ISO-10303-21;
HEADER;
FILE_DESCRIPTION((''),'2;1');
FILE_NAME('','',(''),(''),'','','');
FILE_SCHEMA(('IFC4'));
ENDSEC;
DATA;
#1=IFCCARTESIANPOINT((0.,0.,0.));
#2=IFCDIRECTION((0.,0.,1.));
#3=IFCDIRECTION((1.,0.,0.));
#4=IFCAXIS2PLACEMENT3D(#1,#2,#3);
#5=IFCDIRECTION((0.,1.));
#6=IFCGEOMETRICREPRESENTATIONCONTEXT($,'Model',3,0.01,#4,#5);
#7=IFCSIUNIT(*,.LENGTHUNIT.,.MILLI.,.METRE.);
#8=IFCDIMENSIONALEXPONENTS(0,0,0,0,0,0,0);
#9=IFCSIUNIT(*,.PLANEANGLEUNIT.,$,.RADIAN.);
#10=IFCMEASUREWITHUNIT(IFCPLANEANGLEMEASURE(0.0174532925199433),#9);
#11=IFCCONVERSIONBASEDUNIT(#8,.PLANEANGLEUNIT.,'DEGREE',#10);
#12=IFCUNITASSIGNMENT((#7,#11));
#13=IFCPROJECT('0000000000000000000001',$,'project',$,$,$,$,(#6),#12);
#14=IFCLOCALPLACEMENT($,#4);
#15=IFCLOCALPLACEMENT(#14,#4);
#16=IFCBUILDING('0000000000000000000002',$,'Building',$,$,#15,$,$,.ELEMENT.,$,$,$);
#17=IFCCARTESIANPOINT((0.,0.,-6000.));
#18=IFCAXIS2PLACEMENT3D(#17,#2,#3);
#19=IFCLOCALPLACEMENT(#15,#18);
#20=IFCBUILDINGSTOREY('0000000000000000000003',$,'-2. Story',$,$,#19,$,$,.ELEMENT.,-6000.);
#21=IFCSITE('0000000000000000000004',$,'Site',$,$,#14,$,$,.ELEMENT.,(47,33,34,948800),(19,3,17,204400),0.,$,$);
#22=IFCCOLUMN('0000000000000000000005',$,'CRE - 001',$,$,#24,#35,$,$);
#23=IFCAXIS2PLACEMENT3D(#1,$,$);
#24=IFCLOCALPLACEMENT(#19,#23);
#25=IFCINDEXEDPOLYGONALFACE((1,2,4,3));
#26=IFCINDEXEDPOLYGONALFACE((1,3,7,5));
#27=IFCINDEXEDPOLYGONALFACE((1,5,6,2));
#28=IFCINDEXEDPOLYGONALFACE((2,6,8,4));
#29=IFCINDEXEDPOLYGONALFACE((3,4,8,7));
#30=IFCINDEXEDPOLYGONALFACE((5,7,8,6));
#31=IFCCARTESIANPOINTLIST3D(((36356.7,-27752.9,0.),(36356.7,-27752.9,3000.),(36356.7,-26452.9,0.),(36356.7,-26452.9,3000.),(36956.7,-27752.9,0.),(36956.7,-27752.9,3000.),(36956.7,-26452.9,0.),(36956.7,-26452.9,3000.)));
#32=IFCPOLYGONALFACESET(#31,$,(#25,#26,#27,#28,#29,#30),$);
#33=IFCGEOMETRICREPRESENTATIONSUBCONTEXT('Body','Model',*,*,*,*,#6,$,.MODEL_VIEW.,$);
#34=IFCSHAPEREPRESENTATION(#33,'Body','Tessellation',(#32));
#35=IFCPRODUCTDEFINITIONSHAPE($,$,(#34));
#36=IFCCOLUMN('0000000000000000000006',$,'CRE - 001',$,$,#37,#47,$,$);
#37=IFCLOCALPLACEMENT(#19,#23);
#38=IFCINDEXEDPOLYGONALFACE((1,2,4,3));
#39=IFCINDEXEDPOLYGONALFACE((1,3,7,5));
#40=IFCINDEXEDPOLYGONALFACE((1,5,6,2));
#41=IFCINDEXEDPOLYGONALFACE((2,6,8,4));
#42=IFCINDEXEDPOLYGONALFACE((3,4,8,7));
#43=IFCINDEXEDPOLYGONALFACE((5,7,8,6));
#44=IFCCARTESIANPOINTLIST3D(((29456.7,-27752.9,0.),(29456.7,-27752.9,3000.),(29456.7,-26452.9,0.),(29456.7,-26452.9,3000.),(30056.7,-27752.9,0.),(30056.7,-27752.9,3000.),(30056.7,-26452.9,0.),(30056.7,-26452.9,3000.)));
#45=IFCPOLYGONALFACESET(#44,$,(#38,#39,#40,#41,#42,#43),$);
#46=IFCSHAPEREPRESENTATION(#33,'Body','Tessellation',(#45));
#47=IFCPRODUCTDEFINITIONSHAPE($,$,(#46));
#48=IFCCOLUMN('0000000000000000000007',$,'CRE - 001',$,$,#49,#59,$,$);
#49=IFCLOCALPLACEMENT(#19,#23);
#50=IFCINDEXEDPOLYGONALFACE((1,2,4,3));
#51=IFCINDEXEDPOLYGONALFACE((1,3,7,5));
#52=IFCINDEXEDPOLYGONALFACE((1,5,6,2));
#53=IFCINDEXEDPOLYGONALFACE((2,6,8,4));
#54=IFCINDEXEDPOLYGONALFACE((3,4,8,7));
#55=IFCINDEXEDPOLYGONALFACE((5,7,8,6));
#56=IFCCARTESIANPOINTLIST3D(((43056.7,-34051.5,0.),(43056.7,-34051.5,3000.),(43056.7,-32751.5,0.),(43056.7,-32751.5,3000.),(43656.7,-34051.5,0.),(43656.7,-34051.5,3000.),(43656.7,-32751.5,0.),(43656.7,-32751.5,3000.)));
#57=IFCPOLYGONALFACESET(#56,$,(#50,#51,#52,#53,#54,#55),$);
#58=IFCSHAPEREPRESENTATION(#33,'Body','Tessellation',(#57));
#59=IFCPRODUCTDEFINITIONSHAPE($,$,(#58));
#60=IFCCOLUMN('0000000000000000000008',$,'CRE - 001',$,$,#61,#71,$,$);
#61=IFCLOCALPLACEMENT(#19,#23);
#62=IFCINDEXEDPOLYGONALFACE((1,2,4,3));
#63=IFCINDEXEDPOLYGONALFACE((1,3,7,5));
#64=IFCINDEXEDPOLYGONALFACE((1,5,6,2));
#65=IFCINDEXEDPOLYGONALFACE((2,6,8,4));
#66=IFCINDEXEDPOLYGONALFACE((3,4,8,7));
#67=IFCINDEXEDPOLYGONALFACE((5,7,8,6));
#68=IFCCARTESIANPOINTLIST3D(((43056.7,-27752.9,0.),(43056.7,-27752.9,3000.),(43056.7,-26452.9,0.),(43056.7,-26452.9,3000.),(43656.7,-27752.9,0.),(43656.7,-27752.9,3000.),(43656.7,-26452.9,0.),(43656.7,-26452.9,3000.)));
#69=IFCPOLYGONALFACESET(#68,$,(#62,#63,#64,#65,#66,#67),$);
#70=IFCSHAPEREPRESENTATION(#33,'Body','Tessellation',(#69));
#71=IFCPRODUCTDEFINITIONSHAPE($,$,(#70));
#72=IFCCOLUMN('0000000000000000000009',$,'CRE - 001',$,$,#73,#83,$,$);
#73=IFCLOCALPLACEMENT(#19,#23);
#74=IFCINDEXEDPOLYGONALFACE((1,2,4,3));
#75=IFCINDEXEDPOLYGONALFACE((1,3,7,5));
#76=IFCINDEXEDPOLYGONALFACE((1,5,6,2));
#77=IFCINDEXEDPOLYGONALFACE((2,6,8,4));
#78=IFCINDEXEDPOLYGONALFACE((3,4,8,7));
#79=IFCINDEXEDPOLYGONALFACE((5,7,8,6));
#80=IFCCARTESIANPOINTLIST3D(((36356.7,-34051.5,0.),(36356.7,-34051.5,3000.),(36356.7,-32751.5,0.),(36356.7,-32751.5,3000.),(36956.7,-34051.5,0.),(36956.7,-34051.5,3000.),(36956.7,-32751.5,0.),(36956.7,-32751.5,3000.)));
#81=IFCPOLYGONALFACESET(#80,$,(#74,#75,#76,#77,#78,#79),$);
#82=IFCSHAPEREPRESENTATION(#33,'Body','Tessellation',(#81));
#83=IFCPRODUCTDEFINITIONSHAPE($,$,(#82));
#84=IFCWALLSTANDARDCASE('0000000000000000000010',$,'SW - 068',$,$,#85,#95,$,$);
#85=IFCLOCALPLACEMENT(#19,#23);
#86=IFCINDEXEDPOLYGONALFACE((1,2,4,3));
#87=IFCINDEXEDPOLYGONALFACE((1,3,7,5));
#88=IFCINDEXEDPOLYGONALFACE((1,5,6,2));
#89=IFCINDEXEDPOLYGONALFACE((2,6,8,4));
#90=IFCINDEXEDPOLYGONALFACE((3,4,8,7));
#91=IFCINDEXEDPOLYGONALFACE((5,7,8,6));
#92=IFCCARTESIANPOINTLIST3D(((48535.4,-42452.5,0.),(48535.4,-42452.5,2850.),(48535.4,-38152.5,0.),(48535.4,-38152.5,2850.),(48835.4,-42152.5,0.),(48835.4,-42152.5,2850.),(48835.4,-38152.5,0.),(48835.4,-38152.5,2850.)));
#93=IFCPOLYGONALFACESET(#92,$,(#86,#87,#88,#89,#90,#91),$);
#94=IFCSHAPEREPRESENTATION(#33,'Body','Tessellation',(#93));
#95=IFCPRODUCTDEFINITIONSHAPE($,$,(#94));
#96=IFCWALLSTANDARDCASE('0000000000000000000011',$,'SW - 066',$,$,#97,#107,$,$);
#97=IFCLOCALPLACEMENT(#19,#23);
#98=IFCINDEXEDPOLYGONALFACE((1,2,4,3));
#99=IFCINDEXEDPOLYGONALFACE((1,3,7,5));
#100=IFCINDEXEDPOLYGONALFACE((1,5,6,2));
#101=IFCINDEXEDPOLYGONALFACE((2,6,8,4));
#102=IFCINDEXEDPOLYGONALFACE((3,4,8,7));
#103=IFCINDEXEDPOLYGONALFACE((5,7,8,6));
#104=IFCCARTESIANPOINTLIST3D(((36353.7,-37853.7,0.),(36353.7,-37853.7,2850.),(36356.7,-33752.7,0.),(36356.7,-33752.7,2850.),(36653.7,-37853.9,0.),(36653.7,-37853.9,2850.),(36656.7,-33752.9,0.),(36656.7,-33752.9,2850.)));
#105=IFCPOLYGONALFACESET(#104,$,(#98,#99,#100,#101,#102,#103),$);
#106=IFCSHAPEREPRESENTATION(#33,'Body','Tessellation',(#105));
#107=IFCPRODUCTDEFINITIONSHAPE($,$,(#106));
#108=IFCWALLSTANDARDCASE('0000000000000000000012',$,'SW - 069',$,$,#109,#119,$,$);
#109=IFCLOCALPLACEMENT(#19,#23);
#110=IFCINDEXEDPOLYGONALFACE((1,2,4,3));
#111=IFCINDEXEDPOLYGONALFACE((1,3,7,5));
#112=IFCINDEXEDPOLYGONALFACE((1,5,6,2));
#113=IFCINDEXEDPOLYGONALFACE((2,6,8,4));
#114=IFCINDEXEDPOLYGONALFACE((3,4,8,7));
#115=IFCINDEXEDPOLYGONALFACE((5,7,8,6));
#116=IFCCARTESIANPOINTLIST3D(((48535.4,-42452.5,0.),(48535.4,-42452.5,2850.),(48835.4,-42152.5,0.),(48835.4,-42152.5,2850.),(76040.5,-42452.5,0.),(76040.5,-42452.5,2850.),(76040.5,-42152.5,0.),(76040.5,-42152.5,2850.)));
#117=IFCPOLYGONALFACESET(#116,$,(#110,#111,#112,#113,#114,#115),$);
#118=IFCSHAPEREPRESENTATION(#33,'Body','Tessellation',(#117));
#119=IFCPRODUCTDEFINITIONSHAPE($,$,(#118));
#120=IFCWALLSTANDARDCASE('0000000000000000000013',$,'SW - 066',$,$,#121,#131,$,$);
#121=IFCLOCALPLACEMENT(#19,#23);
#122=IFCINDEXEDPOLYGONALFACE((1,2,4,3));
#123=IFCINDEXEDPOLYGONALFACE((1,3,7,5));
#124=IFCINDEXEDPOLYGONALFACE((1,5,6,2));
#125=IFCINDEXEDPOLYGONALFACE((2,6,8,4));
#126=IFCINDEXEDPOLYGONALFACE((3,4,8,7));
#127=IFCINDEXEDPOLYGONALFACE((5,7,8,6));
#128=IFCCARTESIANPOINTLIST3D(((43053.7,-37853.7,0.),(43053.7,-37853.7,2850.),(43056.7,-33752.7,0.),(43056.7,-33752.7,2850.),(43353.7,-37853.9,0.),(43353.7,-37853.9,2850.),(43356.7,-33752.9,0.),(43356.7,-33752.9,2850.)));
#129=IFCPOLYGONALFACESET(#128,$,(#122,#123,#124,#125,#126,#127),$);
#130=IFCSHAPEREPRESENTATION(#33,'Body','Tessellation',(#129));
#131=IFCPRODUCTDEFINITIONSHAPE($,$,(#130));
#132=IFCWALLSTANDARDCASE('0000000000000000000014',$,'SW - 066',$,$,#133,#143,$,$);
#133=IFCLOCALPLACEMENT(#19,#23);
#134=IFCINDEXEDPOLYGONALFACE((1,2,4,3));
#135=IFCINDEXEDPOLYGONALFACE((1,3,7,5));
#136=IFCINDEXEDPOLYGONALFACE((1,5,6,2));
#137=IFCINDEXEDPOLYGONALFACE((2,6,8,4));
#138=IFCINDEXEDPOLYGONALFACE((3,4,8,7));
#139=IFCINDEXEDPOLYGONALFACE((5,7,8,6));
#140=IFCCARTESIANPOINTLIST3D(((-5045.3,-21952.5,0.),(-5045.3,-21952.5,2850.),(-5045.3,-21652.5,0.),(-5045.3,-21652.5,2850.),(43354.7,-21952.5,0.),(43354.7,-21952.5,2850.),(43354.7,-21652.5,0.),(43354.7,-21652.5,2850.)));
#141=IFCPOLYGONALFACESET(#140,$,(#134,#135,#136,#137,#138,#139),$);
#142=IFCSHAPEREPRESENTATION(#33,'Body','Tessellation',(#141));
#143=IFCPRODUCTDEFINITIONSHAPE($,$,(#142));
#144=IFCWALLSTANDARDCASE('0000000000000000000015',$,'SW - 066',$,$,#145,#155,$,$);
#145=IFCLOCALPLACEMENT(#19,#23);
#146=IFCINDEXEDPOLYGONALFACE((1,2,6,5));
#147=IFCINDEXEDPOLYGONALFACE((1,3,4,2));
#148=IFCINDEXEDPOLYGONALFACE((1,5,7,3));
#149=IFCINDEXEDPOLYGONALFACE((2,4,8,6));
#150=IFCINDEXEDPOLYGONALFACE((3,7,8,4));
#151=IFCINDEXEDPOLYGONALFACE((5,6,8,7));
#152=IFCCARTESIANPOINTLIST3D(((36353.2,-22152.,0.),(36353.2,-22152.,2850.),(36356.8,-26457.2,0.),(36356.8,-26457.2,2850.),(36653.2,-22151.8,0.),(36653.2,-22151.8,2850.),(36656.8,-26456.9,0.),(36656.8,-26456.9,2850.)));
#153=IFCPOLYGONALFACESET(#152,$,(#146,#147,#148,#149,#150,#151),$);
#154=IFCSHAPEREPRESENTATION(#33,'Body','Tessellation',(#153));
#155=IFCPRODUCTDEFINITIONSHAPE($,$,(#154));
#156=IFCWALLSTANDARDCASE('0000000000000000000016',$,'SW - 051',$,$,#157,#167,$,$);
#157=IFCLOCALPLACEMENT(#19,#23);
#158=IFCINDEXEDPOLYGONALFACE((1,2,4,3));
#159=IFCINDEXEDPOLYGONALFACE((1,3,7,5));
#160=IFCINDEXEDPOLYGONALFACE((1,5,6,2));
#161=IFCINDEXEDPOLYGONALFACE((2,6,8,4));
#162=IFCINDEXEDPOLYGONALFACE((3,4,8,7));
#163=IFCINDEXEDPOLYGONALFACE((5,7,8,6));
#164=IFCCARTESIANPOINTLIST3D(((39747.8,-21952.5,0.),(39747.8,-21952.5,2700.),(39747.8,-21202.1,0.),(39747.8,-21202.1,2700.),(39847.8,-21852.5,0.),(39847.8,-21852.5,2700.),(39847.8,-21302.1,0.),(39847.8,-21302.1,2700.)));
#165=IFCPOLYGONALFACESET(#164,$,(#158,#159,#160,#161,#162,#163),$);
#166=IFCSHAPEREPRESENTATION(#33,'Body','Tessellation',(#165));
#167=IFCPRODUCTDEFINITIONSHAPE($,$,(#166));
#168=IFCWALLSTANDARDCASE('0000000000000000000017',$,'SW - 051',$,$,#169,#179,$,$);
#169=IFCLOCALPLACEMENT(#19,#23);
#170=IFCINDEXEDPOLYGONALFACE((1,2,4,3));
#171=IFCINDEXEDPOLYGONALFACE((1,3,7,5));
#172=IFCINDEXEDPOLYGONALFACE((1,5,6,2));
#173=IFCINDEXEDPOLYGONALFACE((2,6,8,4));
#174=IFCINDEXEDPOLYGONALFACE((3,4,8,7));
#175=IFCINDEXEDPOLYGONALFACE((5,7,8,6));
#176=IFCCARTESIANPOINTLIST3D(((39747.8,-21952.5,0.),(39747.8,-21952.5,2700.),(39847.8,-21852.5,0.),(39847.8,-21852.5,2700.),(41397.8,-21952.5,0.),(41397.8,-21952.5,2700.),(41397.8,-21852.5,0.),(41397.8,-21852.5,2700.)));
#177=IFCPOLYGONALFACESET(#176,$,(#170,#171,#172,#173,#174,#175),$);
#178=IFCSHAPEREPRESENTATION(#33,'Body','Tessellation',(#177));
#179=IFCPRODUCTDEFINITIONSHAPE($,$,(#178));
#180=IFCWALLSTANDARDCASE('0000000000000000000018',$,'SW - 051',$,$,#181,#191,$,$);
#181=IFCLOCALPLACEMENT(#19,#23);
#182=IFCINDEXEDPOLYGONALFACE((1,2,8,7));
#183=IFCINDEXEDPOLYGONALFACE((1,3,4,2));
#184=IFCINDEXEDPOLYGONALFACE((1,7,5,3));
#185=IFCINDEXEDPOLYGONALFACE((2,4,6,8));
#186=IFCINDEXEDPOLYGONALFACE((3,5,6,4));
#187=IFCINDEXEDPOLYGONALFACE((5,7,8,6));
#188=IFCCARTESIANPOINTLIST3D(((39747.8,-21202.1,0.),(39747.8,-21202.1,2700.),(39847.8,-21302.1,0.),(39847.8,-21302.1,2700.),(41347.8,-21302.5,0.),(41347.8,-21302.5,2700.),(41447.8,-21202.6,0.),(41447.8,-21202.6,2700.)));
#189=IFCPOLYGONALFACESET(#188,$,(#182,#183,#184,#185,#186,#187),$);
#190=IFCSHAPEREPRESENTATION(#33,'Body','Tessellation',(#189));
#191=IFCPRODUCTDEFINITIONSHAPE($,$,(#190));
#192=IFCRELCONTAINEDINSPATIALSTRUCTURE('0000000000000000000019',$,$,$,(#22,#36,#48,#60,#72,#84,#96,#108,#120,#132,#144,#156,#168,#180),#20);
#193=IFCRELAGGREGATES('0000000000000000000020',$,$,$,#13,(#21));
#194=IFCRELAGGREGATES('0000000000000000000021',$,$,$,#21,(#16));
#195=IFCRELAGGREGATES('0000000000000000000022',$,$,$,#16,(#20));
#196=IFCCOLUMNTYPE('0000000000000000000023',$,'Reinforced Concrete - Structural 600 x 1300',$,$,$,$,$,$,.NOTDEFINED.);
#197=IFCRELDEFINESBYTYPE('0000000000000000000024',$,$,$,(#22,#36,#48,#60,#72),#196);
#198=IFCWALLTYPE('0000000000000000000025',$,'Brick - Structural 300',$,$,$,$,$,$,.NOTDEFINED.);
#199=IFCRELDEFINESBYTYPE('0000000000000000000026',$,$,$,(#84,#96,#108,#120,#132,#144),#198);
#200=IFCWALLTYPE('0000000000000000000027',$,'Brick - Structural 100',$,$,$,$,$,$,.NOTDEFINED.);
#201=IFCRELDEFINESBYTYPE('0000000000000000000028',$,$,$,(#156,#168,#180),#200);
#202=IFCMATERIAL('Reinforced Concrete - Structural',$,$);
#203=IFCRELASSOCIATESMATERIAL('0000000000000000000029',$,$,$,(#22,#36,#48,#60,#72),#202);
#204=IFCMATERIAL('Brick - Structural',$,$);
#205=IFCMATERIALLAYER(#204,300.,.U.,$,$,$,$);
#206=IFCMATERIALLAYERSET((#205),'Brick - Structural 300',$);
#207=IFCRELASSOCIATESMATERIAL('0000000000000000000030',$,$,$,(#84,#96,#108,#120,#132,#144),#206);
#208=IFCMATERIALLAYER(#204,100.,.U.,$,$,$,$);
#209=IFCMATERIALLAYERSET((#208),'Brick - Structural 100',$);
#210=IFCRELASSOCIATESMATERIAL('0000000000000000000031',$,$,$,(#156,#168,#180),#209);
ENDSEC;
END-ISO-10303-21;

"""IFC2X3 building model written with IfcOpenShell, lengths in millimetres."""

from ifc_helpers import new_model, entity, si_unit, converted_unit, direction, frame, origin_with_axes, origin_2d_with_axis, place, context, subcontext, project, spatial, polyline, rectangle, outline, extrude, material, layer, layer_set, layer_usage, type_object, element, save


model = new_model("IFC2X3")

# Units and contexts
model_context = context("Model", 3, precision=0.01, world=origin_with_axes(), true_north=direction((0.0, 1.0)))
body_context = subcontext(model_context, "Body", "Model", "MODEL_VIEW")
ifc_project = project(units=[si_unit("LENGTHUNIT", "METRE", prefix="MILLI"), converted_unit("PLANEANGLEUNIT", "DEGREE", entity("IfcPlaneAngleMeasure", 0.0174532925199433), si_unit("PLANEANGLEUNIT", "RADIAN"), dimensions=[0, 0, 0, 0, 0, 0, 0])], contexts=[model_context])

# Site, building, storey
site_placement = place(None, origin_with_axes())
site = spatial("IfcSite", under=ifc_project, at=site_placement, Name="Site", CompositionType="ELEMENT", RefLatitude=(47, 33, 34, 948800), RefLongitude=(19, 3, 17, 204400), RefElevation=0.0)
building_placement = place(site_placement, origin_with_axes())
building = spatial("IfcBuilding", under=site, at=building_placement, Name="Building", CompositionType="ELEMENT")
storey_placement = place(building_placement, frame((0.0, 0.0, -6000.0), z_axis=(0.0, 0.0, 1.0), x_axis=(1.0, 0.0, 0.0)))
storey = spatial("IfcBuildingStorey", under=building, at=storey_placement, Name="-2. Story", CompositionType="ELEMENT", Elevation=-6000.0)

# Columns
ifc_material_1 = material(Name="Reinforced Concrete - Structural")
column_type = type_object("IfcColumnType", Name="Reinforced Concrete - Structural 600 x 1300", PredefinedType="NOTDEFINED")
for number, where, z_axis, x_axis, name in (
    (1, (36656.7, -27102.9, 0.0), (0.0, 0.0, 1.0), (1.0, 0.0, 0.0), "CRE - 001"),
    (2, (29756.7, -27102.9, 0.0), (0.0, 0.0, 1.0), (1.0, 0.0, 0.0), "CRE - 001"),
    (3, (43356.7, -33401.5, 0.0), (0.0, 0.0, 1.0), (1.0, 0.0, 0.0), "CRE - 001"),
    (4, (43356.7, -27102.9, 0.0), (0.0, 0.0, 1.0), (1.0, 0.0, 0.0), "CRE - 001"),
    (5, (36656.7, -33401.5, 0.0), (0.0, 0.0, 1.0), (1.0, 0.0, 0.0), "CRE - 001"),
):
    element("IfcColumn", number, at=place(storey_placement, frame(where, z_axis=z_axis, x_axis=x_axis)), inside=storey, type_object=column_type, material=ifc_material_1, Name=name, context=body_context, shape_type="SweptSolid", body=[
        extrude(rectangle(XDim=600.0, YDim=1300.0, at=origin_2d_with_axis()), origin_with_axes(), (0.0, 0.0, 1.0), 3000.0),
    ])

# Walls
ifc_material_2 = material(Name="Brick - Structural")
ifc_layer_1 = layer(ifc_material_2, 300.0, ventilated="UNKNOWN")
ifc_layer_set_1 = layer_set([ifc_layer_1], Name="Brick - Structural 300")
wall_type_1 = type_object("IfcWallType", Name="Brick - Structural 300", PredefinedType="NOTDEFINED")
ifc_layer_usage_1 = layer_usage(ifc_layer_set_1, "AXIS2", "POSITIVE", 0.0)
wall_1_placement = place(storey_placement, frame((48535.4, -38152.5, 0.0), z_axis=(0.0, 0.0, 1.0), x_axis=(0.0, -1.0, 0.0)))
element("IfcWallStandardCase", 6, at=wall_1_placement, inside=storey, type_object=wall_type_1, material=ifc_layer_usage_1, Name="SW - 068", context=body_context, shape_type="SweptSolid", body=[
    extrude(outline(polyline([(0.0, 0.0), (4300.0, 0.0), (4000.0, 300.0), (0.0, 300.0), (0.0, 0.0)])), origin_with_axes(), (0.0, 0.0, 1.0), 2850.0),
])
ifc_layer_usage_2 = layer_usage(ifc_layer_set_1, "AXIS2", "POSITIVE", 0.0)
wall_2_placement = place(storey_placement, frame((36356.7, -33752.7, 0.0), z_axis=(0.0, 0.0, 1.0), x_axis=(-0.000749, -1.0, 0.0)))
element("IfcWallStandardCase", 7, at=wall_2_placement, inside=storey, type_object=wall_type_1, material=ifc_layer_usage_2, Name="SW - 066", context=body_context, shape_type="SweptSolid", body=[
    extrude(outline(polyline([(0.0, 0.0), (4101.0, 0.0), (4101.0, 300.0), (0.0, 300.0), (0.0, 0.0)])), origin_with_axes(), (0.0, 0.0, 1.0), 2850.0),
])
ifc_layer_usage_3 = layer_usage(ifc_layer_set_1, "AXIS2", "POSITIVE", 0.0)
wall_3_placement = place(storey_placement, frame((48535.4, -42452.5, 0.0), z_axis=(0.0, 0.0, 1.0), x_axis=(1.0, 0.0, 0.0)))
element("IfcWallStandardCase", 8, at=wall_3_placement, inside=storey, type_object=wall_type_1, material=ifc_layer_usage_3, Name="SW - 069", context=body_context, shape_type="SweptSolid", body=[
    extrude(outline(polyline([(0.0, 0.0), (27505.0, 0.0), (27505.0, 300.0), (300.0, 300.0), (0.0, 0.0)])), origin_with_axes(), (0.0, 0.0, 1.0), 2850.0),
])
ifc_layer_usage_4 = layer_usage(ifc_layer_set_1, "AXIS2", "POSITIVE", 0.0)
wall_4_placement = place(storey_placement, frame((43056.7, -33752.7, 0.0), z_axis=(0.0, 0.0, 1.0), x_axis=(-0.000749, -1.0, 0.0)))
element("IfcWallStandardCase", 9, at=wall_4_placement, inside=storey, type_object=wall_type_1, material=ifc_layer_usage_4, Name="SW - 066", context=body_context, shape_type="SweptSolid", body=[
    extrude(outline(polyline([(0.0, 0.0), (4101.0, 0.0), (4101.0, 300.0), (0.0, 300.0), (0.0, 0.0)])), origin_with_axes(), (0.0, 0.0, 1.0), 2850.0),
])
ifc_layer_usage_5 = layer_usage(ifc_layer_set_1, "AXIS2", "POSITIVE", 0.0)
wall_5_placement = place(storey_placement, frame((43354.7, -21652.5, 0.0), z_axis=(0.0, 0.0, 1.0), x_axis=(-1.0, 0.0, 0.0)))
element("IfcWallStandardCase", 10, at=wall_5_placement, inside=storey, type_object=wall_type_1, material=ifc_layer_usage_5, Name="SW - 066", context=body_context, shape_type="SweptSolid", body=[
    extrude(outline(polyline([(0.0, 0.0), (48400.0, 0.0), (48400.0, 300.0), (0.0, 300.0), (0.0, 0.0)])), origin_with_axes(), (0.0, 0.0, 1.0), 2850.0),
])
ifc_layer_usage_6 = layer_usage(ifc_layer_set_1, "AXIS2", "POSITIVE", 0.0)
wall_6_placement = place(storey_placement, frame((36353.2, -22152.0, 0.0), z_axis=(0.0, 0.0, 1.0), x_axis=(0.000847, -1.0, 0.0)))
element("IfcWallStandardCase", 11, at=wall_6_placement, inside=storey, type_object=wall_type_1, material=ifc_layer_usage_6, Name="SW - 066", context=body_context, shape_type="SweptSolid", body=[
    extrude(outline(polyline([(0.0, 0.0), (4305.1, 0.0), (4305.1, 300.0), (0.0, 300.0), (0.0, 0.0)])), origin_with_axes(), (0.0, 0.0, 1.0), 2850.0),
])
ifc_layer_2 = layer(ifc_material_2, 100.0, ventilated="UNKNOWN")
ifc_layer_set_2 = layer_set([ifc_layer_2], Name="Brick - Structural 100")
ifc_layer_usage_7 = layer_usage(ifc_layer_set_2, "AXIS2", "NEGATIVE", 0.0)
wall_type_2 = type_object("IfcWallType", Name="Brick - Structural 100", PredefinedType="NOTDEFINED")
wall_7_placement = place(storey_placement, frame((39747.8, -21952.5, 0.0), z_axis=(0.0, 0.0, 1.0), x_axis=(0.0, 1.0, 0.0)))
element("IfcWallStandardCase", 12, at=wall_7_placement, inside=storey, type_object=wall_type_2, material=ifc_layer_usage_7, Name="SW - 051", context=body_context, shape_type="SweptSolid", body=[
    extrude(outline(polyline([(100.0, -100.0), (650.4, -100.0), (750.4, 0.0), (0.0, 0.0), (100.0, -100.0)])), origin_with_axes(), (0.0, 0.0, 1.0), 2700.0),
])
ifc_layer_usage_8 = layer_usage(ifc_layer_set_2, "AXIS2", "NEGATIVE", 0.0)
wall_8_placement = place(storey_placement, frame((41397.8, -21952.5, 0.0), z_axis=(0.0, 0.0, 1.0), x_axis=(-1.0, 0.0, 0.0)))
element("IfcWallStandardCase", 13, at=wall_8_placement, inside=storey, type_object=wall_type_2, material=ifc_layer_usage_8, Name="SW - 051", context=body_context, shape_type="SweptSolid", body=[
    extrude(outline(polyline([(0.0, -100.0), (1550.0, -100.0), (1650.0, 0.0), (0.0, 0.0), (0.0, -100.0)])), origin_with_axes(), (0.0, 0.0, 1.0), 2700.0),
])
ifc_layer_usage_9 = layer_usage(ifc_layer_set_2, "AXIS2", "NEGATIVE", 0.0)
wall_9_placement = place(storey_placement, frame((41347.8, -21302.5, 0.0), z_axis=(0.0, 0.0, 1.0), x_axis=(-1.0, 0.000256, 0.0)))
element("IfcWallStandardCase", 14, at=wall_9_placement, inside=storey, type_object=wall_type_2, material=ifc_layer_usage_9, Name="SW - 051", context=body_context, shape_type="SweptSolid", body=[
    extrude(outline(polyline([(-100.0, -100.0), (1600.0, -100.0), (1500.0, 0.0), (0.0, 0.0), (-100.0, -100.0)])), origin_with_axes(), (0.0, 0.0, 1.0), 2700.0),
])

save(model, "model.ifc")
